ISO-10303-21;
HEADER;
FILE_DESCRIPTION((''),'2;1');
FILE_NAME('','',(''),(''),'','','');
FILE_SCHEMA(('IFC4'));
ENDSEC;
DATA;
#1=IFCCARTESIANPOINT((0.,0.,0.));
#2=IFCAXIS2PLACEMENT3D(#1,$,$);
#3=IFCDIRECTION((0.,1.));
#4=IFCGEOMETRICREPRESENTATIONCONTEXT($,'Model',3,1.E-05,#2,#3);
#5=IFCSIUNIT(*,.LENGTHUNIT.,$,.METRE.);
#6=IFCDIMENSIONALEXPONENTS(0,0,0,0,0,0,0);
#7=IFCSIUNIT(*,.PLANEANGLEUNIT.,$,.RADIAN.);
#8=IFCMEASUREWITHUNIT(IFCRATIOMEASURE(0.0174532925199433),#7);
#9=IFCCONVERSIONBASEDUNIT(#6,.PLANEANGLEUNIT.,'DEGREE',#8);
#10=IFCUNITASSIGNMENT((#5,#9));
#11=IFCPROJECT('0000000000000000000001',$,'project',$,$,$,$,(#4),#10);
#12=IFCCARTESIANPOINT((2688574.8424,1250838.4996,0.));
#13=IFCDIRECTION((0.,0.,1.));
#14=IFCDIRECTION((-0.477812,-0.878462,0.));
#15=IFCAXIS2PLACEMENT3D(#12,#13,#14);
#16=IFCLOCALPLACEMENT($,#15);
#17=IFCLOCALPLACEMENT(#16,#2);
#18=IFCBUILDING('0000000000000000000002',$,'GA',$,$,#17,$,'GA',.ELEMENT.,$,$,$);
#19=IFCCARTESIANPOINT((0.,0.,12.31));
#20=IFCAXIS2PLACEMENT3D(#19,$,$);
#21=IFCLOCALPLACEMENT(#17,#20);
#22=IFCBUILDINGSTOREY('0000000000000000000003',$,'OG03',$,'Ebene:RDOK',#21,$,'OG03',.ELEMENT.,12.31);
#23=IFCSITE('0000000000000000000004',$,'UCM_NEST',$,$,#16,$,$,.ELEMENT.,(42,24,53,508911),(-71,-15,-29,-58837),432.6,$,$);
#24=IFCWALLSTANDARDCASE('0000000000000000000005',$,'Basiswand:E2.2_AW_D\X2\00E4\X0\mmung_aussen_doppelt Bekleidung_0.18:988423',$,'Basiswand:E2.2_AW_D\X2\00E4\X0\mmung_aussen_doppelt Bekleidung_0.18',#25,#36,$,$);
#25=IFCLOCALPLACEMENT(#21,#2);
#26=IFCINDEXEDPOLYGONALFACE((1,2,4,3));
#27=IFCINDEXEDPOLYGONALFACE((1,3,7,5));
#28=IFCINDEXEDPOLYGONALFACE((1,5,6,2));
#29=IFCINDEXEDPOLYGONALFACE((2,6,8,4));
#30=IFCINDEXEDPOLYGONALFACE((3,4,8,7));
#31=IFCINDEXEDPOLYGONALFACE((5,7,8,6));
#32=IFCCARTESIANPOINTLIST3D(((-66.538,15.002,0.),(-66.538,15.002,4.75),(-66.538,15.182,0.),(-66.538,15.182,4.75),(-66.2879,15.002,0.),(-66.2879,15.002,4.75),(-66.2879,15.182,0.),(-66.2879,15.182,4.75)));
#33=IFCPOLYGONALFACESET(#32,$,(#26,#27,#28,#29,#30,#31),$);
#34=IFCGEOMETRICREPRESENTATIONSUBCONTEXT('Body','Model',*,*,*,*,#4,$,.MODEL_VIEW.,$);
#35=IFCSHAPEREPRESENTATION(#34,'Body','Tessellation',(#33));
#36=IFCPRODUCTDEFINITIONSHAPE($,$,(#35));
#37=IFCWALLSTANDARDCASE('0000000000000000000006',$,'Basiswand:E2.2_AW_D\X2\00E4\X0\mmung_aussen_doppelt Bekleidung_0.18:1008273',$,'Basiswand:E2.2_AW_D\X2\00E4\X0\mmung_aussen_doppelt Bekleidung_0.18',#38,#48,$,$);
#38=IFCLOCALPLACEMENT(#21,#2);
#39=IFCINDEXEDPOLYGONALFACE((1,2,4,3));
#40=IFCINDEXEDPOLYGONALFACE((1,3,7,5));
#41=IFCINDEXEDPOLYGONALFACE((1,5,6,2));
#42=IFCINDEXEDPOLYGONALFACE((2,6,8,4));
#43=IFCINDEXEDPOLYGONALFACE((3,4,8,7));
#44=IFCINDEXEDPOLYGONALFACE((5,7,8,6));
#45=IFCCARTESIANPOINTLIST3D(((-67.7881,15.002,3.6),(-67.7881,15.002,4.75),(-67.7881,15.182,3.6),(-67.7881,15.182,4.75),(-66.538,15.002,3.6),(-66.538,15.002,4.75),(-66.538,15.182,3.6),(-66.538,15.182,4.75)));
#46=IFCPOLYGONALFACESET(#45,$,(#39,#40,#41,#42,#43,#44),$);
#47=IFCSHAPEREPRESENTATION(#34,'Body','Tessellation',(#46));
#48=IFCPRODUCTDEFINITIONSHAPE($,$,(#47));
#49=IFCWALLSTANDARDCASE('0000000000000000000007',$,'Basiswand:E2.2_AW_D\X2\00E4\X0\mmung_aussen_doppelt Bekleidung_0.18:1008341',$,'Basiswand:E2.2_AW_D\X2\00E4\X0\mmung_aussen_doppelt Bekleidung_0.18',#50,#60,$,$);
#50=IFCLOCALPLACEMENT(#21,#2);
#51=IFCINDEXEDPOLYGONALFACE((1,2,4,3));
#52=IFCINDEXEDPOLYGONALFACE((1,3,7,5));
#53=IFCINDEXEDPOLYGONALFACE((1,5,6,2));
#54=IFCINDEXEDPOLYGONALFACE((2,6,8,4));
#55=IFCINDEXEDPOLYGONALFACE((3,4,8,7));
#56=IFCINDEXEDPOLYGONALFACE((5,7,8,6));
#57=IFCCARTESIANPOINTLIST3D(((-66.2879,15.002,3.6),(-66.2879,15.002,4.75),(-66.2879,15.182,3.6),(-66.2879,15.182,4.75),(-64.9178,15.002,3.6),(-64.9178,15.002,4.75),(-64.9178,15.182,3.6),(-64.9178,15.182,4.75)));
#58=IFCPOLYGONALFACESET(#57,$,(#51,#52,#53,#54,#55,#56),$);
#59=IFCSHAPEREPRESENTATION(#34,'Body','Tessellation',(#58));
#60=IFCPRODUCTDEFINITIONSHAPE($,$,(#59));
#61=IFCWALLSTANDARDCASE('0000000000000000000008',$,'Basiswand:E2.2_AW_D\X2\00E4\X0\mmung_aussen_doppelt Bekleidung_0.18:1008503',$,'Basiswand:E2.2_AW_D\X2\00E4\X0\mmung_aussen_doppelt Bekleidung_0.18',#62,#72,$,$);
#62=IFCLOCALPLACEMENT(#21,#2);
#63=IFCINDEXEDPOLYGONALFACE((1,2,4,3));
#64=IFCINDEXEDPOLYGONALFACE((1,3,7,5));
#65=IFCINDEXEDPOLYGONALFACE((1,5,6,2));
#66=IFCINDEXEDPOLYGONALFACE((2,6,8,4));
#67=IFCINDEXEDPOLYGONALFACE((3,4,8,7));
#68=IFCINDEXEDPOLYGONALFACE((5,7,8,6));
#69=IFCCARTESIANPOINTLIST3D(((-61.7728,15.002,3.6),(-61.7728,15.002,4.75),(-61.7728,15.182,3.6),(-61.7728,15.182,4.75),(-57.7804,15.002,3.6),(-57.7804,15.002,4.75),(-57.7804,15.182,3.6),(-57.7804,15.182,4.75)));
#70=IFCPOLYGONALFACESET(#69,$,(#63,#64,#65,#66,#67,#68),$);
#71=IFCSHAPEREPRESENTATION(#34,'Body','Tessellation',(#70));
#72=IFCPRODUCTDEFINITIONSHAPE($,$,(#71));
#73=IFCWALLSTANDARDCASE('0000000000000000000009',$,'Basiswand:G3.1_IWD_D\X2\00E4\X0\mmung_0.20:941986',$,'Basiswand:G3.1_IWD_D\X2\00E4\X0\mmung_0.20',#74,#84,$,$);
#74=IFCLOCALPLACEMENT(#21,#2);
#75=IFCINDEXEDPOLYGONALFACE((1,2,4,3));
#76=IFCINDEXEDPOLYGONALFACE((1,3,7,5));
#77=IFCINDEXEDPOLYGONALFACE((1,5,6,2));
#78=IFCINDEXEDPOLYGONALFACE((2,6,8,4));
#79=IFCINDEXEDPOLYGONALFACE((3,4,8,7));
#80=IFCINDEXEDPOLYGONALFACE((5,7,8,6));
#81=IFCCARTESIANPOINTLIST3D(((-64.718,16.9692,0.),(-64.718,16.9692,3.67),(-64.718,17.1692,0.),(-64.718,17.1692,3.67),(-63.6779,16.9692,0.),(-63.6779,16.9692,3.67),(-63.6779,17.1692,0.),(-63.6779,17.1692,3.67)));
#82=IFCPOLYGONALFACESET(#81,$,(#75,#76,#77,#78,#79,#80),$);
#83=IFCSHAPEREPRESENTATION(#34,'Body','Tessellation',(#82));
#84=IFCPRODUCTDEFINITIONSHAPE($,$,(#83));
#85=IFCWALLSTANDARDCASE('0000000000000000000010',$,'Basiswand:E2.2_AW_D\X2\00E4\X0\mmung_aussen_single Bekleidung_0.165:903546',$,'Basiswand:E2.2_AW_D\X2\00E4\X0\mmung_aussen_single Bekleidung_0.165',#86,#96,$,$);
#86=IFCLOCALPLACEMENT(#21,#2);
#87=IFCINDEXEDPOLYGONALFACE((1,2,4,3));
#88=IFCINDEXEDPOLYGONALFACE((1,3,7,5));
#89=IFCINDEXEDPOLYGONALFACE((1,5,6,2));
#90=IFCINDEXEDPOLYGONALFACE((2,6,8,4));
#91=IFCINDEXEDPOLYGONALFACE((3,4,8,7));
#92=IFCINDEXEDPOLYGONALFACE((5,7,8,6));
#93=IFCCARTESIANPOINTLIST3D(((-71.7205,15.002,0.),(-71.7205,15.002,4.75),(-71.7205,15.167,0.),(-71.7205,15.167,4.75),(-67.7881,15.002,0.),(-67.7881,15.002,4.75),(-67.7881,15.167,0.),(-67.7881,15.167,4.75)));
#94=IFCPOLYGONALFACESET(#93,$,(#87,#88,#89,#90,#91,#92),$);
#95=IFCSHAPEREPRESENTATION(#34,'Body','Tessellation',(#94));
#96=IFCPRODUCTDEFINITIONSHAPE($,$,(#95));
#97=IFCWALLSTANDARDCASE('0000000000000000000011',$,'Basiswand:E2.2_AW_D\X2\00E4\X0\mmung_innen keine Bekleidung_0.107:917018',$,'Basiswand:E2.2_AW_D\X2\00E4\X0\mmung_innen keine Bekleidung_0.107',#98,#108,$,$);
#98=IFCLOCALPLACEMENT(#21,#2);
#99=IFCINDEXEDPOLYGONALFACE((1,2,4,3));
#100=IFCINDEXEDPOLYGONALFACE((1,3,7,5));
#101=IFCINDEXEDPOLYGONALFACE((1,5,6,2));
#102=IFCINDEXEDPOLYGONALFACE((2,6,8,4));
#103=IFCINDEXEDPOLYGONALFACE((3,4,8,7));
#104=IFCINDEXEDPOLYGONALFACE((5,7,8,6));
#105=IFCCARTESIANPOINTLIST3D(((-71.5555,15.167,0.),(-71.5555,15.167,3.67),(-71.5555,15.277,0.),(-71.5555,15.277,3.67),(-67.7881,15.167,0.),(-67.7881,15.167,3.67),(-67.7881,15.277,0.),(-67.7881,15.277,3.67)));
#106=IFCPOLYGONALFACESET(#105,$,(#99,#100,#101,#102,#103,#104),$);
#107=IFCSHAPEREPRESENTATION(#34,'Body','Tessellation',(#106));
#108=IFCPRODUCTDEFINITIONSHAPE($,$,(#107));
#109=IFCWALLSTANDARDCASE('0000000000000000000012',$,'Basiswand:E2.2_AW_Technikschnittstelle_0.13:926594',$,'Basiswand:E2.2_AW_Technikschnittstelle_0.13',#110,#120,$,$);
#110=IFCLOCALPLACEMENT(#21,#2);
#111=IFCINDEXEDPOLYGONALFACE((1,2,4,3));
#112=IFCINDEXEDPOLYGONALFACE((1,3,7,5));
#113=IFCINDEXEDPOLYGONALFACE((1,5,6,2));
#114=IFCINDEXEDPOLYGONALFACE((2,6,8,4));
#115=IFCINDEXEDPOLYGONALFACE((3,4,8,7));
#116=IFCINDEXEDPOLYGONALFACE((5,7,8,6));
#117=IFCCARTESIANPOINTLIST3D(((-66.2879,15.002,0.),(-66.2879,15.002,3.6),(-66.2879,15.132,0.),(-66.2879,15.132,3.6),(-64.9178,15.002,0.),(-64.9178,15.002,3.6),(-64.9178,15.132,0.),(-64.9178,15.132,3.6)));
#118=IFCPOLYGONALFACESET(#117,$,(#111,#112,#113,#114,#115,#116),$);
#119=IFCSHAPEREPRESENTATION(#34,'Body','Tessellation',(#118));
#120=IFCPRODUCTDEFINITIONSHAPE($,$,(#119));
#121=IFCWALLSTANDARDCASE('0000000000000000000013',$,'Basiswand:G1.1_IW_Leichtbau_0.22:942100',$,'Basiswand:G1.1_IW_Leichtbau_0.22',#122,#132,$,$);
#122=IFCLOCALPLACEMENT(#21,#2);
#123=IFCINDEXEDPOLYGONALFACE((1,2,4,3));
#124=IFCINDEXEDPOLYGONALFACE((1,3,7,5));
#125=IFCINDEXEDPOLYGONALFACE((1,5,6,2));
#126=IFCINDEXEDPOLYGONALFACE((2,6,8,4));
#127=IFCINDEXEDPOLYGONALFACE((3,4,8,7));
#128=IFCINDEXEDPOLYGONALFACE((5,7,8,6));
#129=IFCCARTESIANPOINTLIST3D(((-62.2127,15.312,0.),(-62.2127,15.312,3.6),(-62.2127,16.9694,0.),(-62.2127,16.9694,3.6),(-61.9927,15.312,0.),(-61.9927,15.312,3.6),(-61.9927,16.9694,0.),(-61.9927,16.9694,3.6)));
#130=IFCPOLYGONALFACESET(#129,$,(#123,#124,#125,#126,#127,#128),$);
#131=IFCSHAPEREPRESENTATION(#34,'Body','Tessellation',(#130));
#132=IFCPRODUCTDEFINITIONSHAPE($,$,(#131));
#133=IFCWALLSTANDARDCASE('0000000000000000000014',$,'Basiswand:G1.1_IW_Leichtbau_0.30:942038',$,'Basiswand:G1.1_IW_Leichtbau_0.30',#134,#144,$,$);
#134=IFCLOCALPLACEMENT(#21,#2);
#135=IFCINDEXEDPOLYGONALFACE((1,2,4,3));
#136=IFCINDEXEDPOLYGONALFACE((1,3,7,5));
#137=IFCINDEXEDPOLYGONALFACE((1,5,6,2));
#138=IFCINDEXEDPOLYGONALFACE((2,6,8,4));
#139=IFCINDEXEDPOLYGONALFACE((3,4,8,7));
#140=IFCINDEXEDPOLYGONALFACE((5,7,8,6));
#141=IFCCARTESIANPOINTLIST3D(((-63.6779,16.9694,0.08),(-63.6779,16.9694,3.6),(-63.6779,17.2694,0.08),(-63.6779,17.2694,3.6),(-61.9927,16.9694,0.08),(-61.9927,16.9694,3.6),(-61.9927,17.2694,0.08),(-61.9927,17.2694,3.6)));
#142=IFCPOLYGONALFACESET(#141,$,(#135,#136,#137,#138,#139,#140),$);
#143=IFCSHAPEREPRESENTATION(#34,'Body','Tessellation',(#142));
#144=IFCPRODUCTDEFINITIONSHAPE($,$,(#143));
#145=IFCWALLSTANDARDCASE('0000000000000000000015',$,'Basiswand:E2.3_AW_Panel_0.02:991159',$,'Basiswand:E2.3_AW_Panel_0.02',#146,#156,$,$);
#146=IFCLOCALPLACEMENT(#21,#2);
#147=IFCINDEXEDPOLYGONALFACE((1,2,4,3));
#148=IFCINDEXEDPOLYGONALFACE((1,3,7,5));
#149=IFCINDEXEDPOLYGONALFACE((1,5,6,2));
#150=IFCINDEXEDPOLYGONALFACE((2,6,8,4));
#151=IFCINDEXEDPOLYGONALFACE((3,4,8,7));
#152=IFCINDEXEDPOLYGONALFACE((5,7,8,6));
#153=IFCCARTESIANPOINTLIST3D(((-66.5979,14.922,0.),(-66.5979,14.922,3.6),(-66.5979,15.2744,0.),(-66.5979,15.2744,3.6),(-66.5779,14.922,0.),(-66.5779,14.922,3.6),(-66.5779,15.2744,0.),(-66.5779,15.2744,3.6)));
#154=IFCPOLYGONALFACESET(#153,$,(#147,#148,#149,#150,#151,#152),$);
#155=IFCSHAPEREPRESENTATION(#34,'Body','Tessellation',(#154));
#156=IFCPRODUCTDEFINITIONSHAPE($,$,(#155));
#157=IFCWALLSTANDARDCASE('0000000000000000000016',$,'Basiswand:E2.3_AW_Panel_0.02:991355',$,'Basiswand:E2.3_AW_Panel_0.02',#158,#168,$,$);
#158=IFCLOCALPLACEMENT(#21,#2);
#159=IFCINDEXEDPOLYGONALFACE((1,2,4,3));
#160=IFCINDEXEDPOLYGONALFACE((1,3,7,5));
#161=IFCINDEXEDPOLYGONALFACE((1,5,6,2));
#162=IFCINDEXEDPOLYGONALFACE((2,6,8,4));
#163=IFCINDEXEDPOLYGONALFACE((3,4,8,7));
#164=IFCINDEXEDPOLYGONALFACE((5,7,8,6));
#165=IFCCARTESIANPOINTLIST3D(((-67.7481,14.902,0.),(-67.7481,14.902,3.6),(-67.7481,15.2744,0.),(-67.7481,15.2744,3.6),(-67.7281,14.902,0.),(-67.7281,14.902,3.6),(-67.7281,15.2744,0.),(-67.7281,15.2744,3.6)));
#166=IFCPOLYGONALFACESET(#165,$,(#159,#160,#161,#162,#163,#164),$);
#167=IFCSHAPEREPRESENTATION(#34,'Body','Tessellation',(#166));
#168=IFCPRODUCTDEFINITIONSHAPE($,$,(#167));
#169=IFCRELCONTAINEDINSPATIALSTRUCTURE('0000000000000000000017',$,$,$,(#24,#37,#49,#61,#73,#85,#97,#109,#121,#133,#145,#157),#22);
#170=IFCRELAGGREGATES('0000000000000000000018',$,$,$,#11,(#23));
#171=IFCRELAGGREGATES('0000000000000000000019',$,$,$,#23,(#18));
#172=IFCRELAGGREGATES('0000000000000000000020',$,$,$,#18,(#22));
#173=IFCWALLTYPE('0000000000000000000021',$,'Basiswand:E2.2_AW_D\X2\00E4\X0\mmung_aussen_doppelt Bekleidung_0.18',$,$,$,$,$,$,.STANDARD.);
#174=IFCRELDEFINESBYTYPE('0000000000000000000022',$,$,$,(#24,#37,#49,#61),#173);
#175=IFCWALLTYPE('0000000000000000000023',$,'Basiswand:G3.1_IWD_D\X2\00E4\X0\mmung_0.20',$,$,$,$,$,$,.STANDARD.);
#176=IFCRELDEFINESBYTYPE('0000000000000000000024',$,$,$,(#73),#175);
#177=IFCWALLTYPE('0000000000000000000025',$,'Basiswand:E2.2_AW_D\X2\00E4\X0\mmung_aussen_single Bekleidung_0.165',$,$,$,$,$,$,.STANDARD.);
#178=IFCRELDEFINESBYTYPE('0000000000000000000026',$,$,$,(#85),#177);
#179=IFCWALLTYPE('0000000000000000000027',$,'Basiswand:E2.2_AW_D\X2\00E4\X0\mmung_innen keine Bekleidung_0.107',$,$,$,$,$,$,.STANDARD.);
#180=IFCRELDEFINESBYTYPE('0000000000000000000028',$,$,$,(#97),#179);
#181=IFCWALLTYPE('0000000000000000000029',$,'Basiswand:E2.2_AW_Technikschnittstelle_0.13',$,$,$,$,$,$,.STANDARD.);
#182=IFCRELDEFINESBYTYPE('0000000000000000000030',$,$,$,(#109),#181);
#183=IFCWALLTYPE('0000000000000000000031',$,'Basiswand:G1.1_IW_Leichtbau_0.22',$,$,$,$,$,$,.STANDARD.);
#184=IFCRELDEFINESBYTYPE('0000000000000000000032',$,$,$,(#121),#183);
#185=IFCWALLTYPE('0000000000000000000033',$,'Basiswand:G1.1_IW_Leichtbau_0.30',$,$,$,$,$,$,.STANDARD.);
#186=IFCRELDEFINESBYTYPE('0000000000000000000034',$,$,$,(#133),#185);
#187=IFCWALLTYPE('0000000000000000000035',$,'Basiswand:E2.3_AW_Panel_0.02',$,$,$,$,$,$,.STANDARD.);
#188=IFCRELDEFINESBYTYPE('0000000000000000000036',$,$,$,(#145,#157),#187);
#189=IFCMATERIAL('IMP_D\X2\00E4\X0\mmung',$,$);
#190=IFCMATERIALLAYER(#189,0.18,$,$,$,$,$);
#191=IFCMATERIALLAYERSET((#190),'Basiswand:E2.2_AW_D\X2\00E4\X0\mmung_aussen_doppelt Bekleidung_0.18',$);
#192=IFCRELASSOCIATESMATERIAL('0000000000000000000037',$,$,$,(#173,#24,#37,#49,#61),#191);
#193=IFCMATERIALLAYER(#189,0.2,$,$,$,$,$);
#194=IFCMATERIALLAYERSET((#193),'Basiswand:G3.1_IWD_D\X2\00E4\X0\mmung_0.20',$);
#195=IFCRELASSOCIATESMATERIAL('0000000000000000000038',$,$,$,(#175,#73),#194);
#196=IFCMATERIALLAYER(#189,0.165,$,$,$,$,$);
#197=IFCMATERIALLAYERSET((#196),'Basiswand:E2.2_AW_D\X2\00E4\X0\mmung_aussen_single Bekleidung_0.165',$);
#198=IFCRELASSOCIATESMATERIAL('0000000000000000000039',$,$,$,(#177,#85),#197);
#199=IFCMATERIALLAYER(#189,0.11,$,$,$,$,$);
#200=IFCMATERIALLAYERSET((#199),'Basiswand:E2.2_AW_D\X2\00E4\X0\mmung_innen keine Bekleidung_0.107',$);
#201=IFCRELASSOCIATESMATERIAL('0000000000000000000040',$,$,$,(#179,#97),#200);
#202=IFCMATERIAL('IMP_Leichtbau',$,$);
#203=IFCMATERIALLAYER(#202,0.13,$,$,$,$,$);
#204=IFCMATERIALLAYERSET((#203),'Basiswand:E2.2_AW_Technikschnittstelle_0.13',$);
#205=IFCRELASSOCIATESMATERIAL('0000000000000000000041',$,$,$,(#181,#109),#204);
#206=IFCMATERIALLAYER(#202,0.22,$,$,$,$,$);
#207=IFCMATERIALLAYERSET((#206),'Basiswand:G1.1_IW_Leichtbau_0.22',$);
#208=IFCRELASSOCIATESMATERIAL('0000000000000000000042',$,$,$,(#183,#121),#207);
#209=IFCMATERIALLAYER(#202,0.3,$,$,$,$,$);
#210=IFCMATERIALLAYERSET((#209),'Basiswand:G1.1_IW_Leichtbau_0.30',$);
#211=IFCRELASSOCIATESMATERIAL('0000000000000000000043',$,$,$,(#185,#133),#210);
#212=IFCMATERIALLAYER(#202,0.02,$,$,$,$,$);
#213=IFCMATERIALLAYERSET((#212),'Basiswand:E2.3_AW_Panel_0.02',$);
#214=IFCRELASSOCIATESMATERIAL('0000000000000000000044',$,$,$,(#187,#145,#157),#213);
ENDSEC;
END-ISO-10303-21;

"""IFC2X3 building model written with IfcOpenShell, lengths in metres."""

from ifc_helpers import new_model, entity, si_unit, converted_unit, direction, frame, frame_2d, origin, place, context, subcontext, project, spatial, polyline, rectangle, extrude, clip, bounded_halfspace, material, layer, layer_set, layer_usage, type_object, element, save


model = new_model("IFC2X3")

# Units and contexts
model_context = context("Model", 3, precision=1e-05, world=origin(), true_north=direction((0.0, 1.0)))
body_context = subcontext(model_context, "Body", "Model", "MODEL_VIEW")
ifc_project = project(units=[si_unit("LENGTHUNIT", "METRE"), converted_unit("PLANEANGLEUNIT", "DEGREE", entity("IfcRatioMeasure", 0.0174532925199433), si_unit("PLANEANGLEUNIT", "RADIAN"), dimensions=[0, 0, 0, 0, 0, 0, 0])], contexts=[model_context])

# Site, building, storey
site_placement = place(None, frame((2688574.8424, 1250838.4996, 0.0), z_axis=(0.0, 0.0, 1.0), x_axis=(-0.477812, -0.878462, 0.0)))
site = spatial("IfcSite", under=ifc_project, at=site_placement, Name="UCM_NEST", CompositionType="ELEMENT", RefLatitude=(42, 24, 53, 508911), RefLongitude=(-71, -15, -29, -58837), RefElevation=432.6)
building_placement = place(site_placement, origin())
building = spatial("IfcBuilding", under=site, at=building_placement, Name="GA", LongName="GA", CompositionType="ELEMENT")
storey_placement = place(building_placement, frame((0.0, 0.0, 12.31)))
storey = spatial("IfcBuildingStorey", under=building, at=storey_placement, Name="OG03", ObjectType="Ebene:RDOK", LongName="OG03", CompositionType="ELEMENT", Elevation=12.31)

# Walls
ifc_material_1 = material(Name="IMP_Dämmung")
ifc_layer_1 = layer(ifc_material_1, 0.18)
ifc_layer_set_1 = layer_set([ifc_layer_1], Name="Basiswand:E2.2_AW_Dämmung_aussen_doppelt Bekleidung_0.18")
wall_type_1 = type_object("IfcWallType", Name="Basiswand:E2.2_AW_Dämmung_aussen_doppelt Bekleidung_0.18", PredefinedType="STANDARD", material=ifc_layer_set_1)
ifc_layer_usage_1 = layer_usage(ifc_layer_set_1, "AXIS2", "NEGATIVE", 0.09)
wall_1_placement = place(storey_placement, frame((-66.2879, 15.092, 0.0), z_axis=(0.0, 0.0, 1.0), x_axis=(-1.0, 0.0, 0.0)))
element("IfcWallStandardCase", 1, at=wall_1_placement, inside=storey, type_object=wall_type_1, material=ifc_layer_usage_1, Name="Basiswand:E2.2_AW_Dämmung_aussen_doppelt Bekleidung_0.18:988423", ObjectType="Basiswand:E2.2_AW_Dämmung_aussen_doppelt Bekleidung_0.18", context=body_context, shape_type="SweptSolid", body=[
    extrude(rectangle(XDim=0.2502, YDim=0.18, at=frame_2d((0.1251, 0.0), x_axis=(-1.0, 0.0))), origin(), (0.0, 0.0, 1.0), 4.75),
])
ifc_layer_usage_2 = layer_usage(ifc_layer_set_1, "AXIS2", "NEGATIVE", 0.09)
wall_2_placement = place(storey_placement, frame((-67.7881, 15.092, 3.6)))
element("IfcWallStandardCase", 2, at=wall_2_placement, inside=storey, type_object=wall_type_1, material=ifc_layer_usage_2, Name="Basiswand:E2.2_AW_Dämmung_aussen_doppelt Bekleidung_0.18:1008273", ObjectType="Basiswand:E2.2_AW_Dämmung_aussen_doppelt Bekleidung_0.18", context=body_context, shape_type="SweptSolid", body=[
    extrude(rectangle(XDim=1.2501, YDim=0.18, at=frame_2d((0.625, 0.0), x_axis=(-1.0, 0.0))), origin(), (0.0, 0.0, 1.0), 1.15),
])
ifc_layer_usage_3 = layer_usage(ifc_layer_set_1, "AXIS2", "NEGATIVE", 0.09)
wall_3_placement = place(storey_placement, frame((-66.2879, 15.092, 3.6)))
element("IfcWallStandardCase", 3, at=wall_3_placement, inside=storey, type_object=wall_type_1, material=ifc_layer_usage_3, Name="Basiswand:E2.2_AW_Dämmung_aussen_doppelt Bekleidung_0.18:1008341", ObjectType="Basiswand:E2.2_AW_Dämmung_aussen_doppelt Bekleidung_0.18", context=body_context, shape_type="SweptSolid", body=[
    extrude(rectangle(XDim=1.3701, YDim=0.18, at=frame_2d((0.685, 0.0), x_axis=(-1.0, 0.0))), origin(), (0.0, 0.0, 1.0), 1.15),
])
ifc_layer_usage_4 = layer_usage(ifc_layer_set_1, "AXIS2", "NEGATIVE", 0.09)
wall_4_placement = place(storey_placement, frame((-61.7728, 15.092, 3.6)))
element("IfcWallStandardCase", 4, at=wall_4_placement, inside=storey, type_object=wall_type_1, material=ifc_layer_usage_4, Name="Basiswand:E2.2_AW_Dämmung_aussen_doppelt Bekleidung_0.18:1008503", ObjectType="Basiswand:E2.2_AW_Dämmung_aussen_doppelt Bekleidung_0.18", context=body_context, shape_type="SweptSolid", body=[
    extrude(rectangle(XDim=3.9923, YDim=0.18, at=frame_2d((1.9962, 0.0), x_axis=(-1.0, 0.0))), origin(), (0.0, 0.0, 1.0), 1.15),
])
ifc_layer_2 = layer(ifc_material_1, 0.2)
ifc_layer_set_2 = layer_set([ifc_layer_2], Name="Basiswand:G3.1_IWD_Dämmung_0.20")
ifc_layer_usage_5 = layer_usage(ifc_layer_set_2, "AXIS2", "NEGATIVE", 0.1)
wall_type_2 = type_object("IfcWallType", Name="Basiswand:G3.1_IWD_Dämmung_0.20", PredefinedType="STANDARD", material=ifc_layer_set_2)
wall_5_placement = place(storey_placement, frame((-64.718, 17.0692, 0.0)))
element("IfcWallStandardCase", 5, at=wall_5_placement, inside=storey, type_object=wall_type_2, material=ifc_layer_usage_5, Name="Basiswand:G3.1_IWD_Dämmung_0.20:941986", ObjectType="Basiswand:G3.1_IWD_Dämmung_0.20", context=body_context, shape_type="SweptSolid", body=[
    extrude(rectangle(XDim=1.0401, YDim=0.2, at=frame_2d((0.52, 0.0), x_axis=(-1.0, 0.0))), origin(), (0.0, 0.0, 1.0), 3.67),
])
ifc_layer_3 = layer(ifc_material_1, 0.165)
ifc_layer_set_3 = layer_set([ifc_layer_3], Name="Basiswand:E2.2_AW_Dämmung_aussen_single Bekleidung_0.165")
ifc_layer_usage_6 = layer_usage(ifc_layer_set_3, "AXIS2", "NEGATIVE", 0.0825)
wall_type_3 = type_object("IfcWallType", Name="Basiswand:E2.2_AW_Dämmung_aussen_single Bekleidung_0.165", PredefinedType="STANDARD", material=ifc_layer_set_3)
wall_6_placement = place(storey_placement, frame((-67.7881, 15.0845, 0.0), z_axis=(0.0, 0.0, 1.0), x_axis=(-1.0, 0.0, 0.0)))
element("IfcWallStandardCase", 6, at=wall_6_placement, inside=storey, type_object=wall_type_3, material=ifc_layer_usage_6, Name="Basiswand:E2.2_AW_Dämmung_aussen_single Bekleidung_0.165:903546", ObjectType="Basiswand:E2.2_AW_Dämmung_aussen_single Bekleidung_0.165", context=body_context, shape_type="SweptSolid", body=[
    extrude(rectangle(XDim=3.9324, YDim=0.165, at=frame_2d((1.9662, 0.0), x_axis=(-1.0, 0.0))), origin(), (0.0, 0.0, 1.0), 4.75),
])

# Wall
ifc_layer_4 = layer(ifc_material_1, 0.11)
ifc_layer_set_4 = layer_set([ifc_layer_4], Name="Basiswand:E2.2_AW_Dämmung_innen keine Bekleidung_0.107")
ifc_layer_usage_7 = layer_usage(ifc_layer_set_4, "AXIS2", "NEGATIVE", 0.055)
wall_type_4 = type_object("IfcWallType", Name="Basiswand:E2.2_AW_Dämmung_innen keine Bekleidung_0.107", PredefinedType="STANDARD", material=ifc_layer_set_4)
wall_7_placement = place(storey_placement, frame((-67.7881, 15.222, 0.0), z_axis=(0.0, 0.0, 1.0), x_axis=(-1.0, 0.0, 0.0)))
element("IfcWallStandardCase", 7, at=wall_7_placement, inside=storey, type_object=wall_type_4, material=ifc_layer_usage_7, Name="Basiswand:E2.2_AW_Dämmung_innen keine Bekleidung_0.107:917018", ObjectType="Basiswand:E2.2_AW_Dämmung_innen keine Bekleidung_0.107", context=body_context, shape_type="SweptSolid", body=[
    extrude(rectangle(XDim=3.7674, YDim=0.11, at=frame_2d((1.8837, 0.0), x_axis=(-1.0, 0.0))), origin(), (0.0, 0.0, 1.0), 3.67),
])

# Walls
ifc_material_2 = material(Name="IMP_Leichtbau")
ifc_layer_5 = layer(ifc_material_2, 0.13)
ifc_layer_set_5 = layer_set([ifc_layer_5], Name="Basiswand:E2.2_AW_Technikschnittstelle_0.13")
ifc_layer_usage_8 = layer_usage(ifc_layer_set_5, "AXIS2", "NEGATIVE", 0.065)
wall_type_5 = type_object("IfcWallType", Name="Basiswand:E2.2_AW_Technikschnittstelle_0.13", PredefinedType="STANDARD", material=ifc_layer_set_5)
wall_8_placement = place(storey_placement, frame((-64.9178, 15.067, 0.0), z_axis=(0.0, 0.0, 1.0), x_axis=(-1.0, 0.0, 0.0)))
element("IfcWallStandardCase", 8, at=wall_8_placement, inside=storey, type_object=wall_type_5, material=ifc_layer_usage_8, Name="Basiswand:E2.2_AW_Technikschnittstelle_0.13:926594", ObjectType="Basiswand:E2.2_AW_Technikschnittstelle_0.13", context=body_context, shape_type="SweptSolid", body=[
    extrude(rectangle(XDim=1.3701, YDim=0.13, at=frame_2d((0.685, 0.0), x_axis=(-1.0, 0.0))), origin(), (0.0, 0.0, 1.0), 3.6),
])
ifc_layer_6 = layer(ifc_material_2, 0.22)
ifc_layer_set_6 = layer_set([ifc_layer_6], Name="Basiswand:G1.1_IW_Leichtbau_0.22")
ifc_layer_usage_9 = layer_usage(ifc_layer_set_6, "AXIS2", "NEGATIVE", 0.11)
wall_type_6 = type_object("IfcWallType", Name="Basiswand:G1.1_IW_Leichtbau_0.22", PredefinedType="STANDARD", material=ifc_layer_set_6)
wall_9_placement = place(storey_placement, frame((-62.1027, 15.312, 0.0), z_axis=(0.0, 0.0, 1.0), x_axis=(0.0, 1.0, 0.0)))
element("IfcWallStandardCase", 9, at=wall_9_placement, inside=storey, type_object=wall_type_6, material=ifc_layer_usage_9, Name="Basiswand:G1.1_IW_Leichtbau_0.22:942100", ObjectType="Basiswand:G1.1_IW_Leichtbau_0.22", context=body_context, shape_type="SweptSolid", body=[
    extrude(rectangle(XDim=1.6575, YDim=0.22, at=frame_2d((0.8287, 0.0), x_axis=(-1.0, 0.0))), origin(), (0.0, 0.0, 1.0), 3.6),
])
ifc_layer_7 = layer(ifc_material_2, 0.3)
ifc_layer_set_7 = layer_set([ifc_layer_7], Name="Basiswand:G1.1_IW_Leichtbau_0.30")
ifc_layer_usage_10 = layer_usage(ifc_layer_set_7, "AXIS2", "NEGATIVE", 0.15)
wall_type_7 = type_object("IfcWallType", Name="Basiswand:G1.1_IW_Leichtbau_0.30", PredefinedType="STANDARD", material=ifc_layer_set_7)
wall_10_placement = place(storey_placement, frame((-61.9927, 17.1194, 0.08), z_axis=(0.0, 0.0, 1.0), x_axis=(-1.0, 0.0, 0.0)))
element("IfcWallStandardCase", 10, at=wall_10_placement, inside=storey, type_object=wall_type_7, material=ifc_layer_usage_10, Name="Basiswand:G1.1_IW_Leichtbau_0.30:942038", ObjectType="Basiswand:G1.1_IW_Leichtbau_0.30", context=body_context, shape_type="Clipping", body=[
    clip(extrude(rectangle(XDim=1.6852, YDim=0.3, at=frame_2d((0.8426, 0.0), x_axis=(-1.0, 0.0))), origin(), (0.0, 0.0, 1.0), 3.52), bounded_halfspace(frame((1.6852, -0.15, 0.0)), True, frame((1.6852, -0.15, 0.0)), polyline([(0.0, 0.0), (0.0, 0.3), (-1.6852, 0.3), (-1.6852, 0.0), (0.0, 0.0)]))),
])
ifc_layer_8 = layer(ifc_material_2, 0.02)
ifc_layer_set_8 = layer_set([ifc_layer_8], Name="Basiswand:E2.3_AW_Panel_0.02")
wall_type_8 = type_object("IfcWallType", Name="Basiswand:E2.3_AW_Panel_0.02", PredefinedType="STANDARD", material=ifc_layer_set_8)
ifc_layer_usage_11 = layer_usage(ifc_layer_set_8, "AXIS2", "NEGATIVE", 0.01)
wall_11_placement = place(storey_placement, frame((-66.5879, 14.922, 0.0), z_axis=(0.0, 0.0, 1.0), x_axis=(0.0, 1.0, 0.0)))
element("IfcWallStandardCase", 11, at=wall_11_placement, inside=storey, type_object=wall_type_8, material=ifc_layer_usage_11, Name="Basiswand:E2.3_AW_Panel_0.02:991159", ObjectType="Basiswand:E2.3_AW_Panel_0.02", context=body_context, shape_type="SweptSolid", body=[
    extrude(rectangle(XDim=0.3525, YDim=0.02, at=frame_2d((0.1762, 0.0), x_axis=(-1.0, 0.0))), origin(), (0.0, 0.0, 1.0), 3.6),
])
ifc_layer_usage_12 = layer_usage(ifc_layer_set_8, "AXIS2", "NEGATIVE", 0.01)
wall_12_placement = place(storey_placement, frame((-67.7381, 15.2744, 0.0), z_axis=(0.0, 0.0, 1.0), x_axis=(0.0, -1.0, 0.0)))
element("IfcWallStandardCase", 12, at=wall_12_placement, inside=storey, type_object=wall_type_8, material=ifc_layer_usage_12, Name="Basiswand:E2.3_AW_Panel_0.02:991355", ObjectType="Basiswand:E2.3_AW_Panel_0.02", context=body_context, shape_type="SweptSolid", body=[
    extrude(rectangle(XDim=0.3724, YDim=0.02, at=frame_2d((0.1862, 0.0), x_axis=(-1.0, 0.0))), origin(), (0.0, 0.0, 1.0), 3.6),
])

save(model, "model.ifc")
